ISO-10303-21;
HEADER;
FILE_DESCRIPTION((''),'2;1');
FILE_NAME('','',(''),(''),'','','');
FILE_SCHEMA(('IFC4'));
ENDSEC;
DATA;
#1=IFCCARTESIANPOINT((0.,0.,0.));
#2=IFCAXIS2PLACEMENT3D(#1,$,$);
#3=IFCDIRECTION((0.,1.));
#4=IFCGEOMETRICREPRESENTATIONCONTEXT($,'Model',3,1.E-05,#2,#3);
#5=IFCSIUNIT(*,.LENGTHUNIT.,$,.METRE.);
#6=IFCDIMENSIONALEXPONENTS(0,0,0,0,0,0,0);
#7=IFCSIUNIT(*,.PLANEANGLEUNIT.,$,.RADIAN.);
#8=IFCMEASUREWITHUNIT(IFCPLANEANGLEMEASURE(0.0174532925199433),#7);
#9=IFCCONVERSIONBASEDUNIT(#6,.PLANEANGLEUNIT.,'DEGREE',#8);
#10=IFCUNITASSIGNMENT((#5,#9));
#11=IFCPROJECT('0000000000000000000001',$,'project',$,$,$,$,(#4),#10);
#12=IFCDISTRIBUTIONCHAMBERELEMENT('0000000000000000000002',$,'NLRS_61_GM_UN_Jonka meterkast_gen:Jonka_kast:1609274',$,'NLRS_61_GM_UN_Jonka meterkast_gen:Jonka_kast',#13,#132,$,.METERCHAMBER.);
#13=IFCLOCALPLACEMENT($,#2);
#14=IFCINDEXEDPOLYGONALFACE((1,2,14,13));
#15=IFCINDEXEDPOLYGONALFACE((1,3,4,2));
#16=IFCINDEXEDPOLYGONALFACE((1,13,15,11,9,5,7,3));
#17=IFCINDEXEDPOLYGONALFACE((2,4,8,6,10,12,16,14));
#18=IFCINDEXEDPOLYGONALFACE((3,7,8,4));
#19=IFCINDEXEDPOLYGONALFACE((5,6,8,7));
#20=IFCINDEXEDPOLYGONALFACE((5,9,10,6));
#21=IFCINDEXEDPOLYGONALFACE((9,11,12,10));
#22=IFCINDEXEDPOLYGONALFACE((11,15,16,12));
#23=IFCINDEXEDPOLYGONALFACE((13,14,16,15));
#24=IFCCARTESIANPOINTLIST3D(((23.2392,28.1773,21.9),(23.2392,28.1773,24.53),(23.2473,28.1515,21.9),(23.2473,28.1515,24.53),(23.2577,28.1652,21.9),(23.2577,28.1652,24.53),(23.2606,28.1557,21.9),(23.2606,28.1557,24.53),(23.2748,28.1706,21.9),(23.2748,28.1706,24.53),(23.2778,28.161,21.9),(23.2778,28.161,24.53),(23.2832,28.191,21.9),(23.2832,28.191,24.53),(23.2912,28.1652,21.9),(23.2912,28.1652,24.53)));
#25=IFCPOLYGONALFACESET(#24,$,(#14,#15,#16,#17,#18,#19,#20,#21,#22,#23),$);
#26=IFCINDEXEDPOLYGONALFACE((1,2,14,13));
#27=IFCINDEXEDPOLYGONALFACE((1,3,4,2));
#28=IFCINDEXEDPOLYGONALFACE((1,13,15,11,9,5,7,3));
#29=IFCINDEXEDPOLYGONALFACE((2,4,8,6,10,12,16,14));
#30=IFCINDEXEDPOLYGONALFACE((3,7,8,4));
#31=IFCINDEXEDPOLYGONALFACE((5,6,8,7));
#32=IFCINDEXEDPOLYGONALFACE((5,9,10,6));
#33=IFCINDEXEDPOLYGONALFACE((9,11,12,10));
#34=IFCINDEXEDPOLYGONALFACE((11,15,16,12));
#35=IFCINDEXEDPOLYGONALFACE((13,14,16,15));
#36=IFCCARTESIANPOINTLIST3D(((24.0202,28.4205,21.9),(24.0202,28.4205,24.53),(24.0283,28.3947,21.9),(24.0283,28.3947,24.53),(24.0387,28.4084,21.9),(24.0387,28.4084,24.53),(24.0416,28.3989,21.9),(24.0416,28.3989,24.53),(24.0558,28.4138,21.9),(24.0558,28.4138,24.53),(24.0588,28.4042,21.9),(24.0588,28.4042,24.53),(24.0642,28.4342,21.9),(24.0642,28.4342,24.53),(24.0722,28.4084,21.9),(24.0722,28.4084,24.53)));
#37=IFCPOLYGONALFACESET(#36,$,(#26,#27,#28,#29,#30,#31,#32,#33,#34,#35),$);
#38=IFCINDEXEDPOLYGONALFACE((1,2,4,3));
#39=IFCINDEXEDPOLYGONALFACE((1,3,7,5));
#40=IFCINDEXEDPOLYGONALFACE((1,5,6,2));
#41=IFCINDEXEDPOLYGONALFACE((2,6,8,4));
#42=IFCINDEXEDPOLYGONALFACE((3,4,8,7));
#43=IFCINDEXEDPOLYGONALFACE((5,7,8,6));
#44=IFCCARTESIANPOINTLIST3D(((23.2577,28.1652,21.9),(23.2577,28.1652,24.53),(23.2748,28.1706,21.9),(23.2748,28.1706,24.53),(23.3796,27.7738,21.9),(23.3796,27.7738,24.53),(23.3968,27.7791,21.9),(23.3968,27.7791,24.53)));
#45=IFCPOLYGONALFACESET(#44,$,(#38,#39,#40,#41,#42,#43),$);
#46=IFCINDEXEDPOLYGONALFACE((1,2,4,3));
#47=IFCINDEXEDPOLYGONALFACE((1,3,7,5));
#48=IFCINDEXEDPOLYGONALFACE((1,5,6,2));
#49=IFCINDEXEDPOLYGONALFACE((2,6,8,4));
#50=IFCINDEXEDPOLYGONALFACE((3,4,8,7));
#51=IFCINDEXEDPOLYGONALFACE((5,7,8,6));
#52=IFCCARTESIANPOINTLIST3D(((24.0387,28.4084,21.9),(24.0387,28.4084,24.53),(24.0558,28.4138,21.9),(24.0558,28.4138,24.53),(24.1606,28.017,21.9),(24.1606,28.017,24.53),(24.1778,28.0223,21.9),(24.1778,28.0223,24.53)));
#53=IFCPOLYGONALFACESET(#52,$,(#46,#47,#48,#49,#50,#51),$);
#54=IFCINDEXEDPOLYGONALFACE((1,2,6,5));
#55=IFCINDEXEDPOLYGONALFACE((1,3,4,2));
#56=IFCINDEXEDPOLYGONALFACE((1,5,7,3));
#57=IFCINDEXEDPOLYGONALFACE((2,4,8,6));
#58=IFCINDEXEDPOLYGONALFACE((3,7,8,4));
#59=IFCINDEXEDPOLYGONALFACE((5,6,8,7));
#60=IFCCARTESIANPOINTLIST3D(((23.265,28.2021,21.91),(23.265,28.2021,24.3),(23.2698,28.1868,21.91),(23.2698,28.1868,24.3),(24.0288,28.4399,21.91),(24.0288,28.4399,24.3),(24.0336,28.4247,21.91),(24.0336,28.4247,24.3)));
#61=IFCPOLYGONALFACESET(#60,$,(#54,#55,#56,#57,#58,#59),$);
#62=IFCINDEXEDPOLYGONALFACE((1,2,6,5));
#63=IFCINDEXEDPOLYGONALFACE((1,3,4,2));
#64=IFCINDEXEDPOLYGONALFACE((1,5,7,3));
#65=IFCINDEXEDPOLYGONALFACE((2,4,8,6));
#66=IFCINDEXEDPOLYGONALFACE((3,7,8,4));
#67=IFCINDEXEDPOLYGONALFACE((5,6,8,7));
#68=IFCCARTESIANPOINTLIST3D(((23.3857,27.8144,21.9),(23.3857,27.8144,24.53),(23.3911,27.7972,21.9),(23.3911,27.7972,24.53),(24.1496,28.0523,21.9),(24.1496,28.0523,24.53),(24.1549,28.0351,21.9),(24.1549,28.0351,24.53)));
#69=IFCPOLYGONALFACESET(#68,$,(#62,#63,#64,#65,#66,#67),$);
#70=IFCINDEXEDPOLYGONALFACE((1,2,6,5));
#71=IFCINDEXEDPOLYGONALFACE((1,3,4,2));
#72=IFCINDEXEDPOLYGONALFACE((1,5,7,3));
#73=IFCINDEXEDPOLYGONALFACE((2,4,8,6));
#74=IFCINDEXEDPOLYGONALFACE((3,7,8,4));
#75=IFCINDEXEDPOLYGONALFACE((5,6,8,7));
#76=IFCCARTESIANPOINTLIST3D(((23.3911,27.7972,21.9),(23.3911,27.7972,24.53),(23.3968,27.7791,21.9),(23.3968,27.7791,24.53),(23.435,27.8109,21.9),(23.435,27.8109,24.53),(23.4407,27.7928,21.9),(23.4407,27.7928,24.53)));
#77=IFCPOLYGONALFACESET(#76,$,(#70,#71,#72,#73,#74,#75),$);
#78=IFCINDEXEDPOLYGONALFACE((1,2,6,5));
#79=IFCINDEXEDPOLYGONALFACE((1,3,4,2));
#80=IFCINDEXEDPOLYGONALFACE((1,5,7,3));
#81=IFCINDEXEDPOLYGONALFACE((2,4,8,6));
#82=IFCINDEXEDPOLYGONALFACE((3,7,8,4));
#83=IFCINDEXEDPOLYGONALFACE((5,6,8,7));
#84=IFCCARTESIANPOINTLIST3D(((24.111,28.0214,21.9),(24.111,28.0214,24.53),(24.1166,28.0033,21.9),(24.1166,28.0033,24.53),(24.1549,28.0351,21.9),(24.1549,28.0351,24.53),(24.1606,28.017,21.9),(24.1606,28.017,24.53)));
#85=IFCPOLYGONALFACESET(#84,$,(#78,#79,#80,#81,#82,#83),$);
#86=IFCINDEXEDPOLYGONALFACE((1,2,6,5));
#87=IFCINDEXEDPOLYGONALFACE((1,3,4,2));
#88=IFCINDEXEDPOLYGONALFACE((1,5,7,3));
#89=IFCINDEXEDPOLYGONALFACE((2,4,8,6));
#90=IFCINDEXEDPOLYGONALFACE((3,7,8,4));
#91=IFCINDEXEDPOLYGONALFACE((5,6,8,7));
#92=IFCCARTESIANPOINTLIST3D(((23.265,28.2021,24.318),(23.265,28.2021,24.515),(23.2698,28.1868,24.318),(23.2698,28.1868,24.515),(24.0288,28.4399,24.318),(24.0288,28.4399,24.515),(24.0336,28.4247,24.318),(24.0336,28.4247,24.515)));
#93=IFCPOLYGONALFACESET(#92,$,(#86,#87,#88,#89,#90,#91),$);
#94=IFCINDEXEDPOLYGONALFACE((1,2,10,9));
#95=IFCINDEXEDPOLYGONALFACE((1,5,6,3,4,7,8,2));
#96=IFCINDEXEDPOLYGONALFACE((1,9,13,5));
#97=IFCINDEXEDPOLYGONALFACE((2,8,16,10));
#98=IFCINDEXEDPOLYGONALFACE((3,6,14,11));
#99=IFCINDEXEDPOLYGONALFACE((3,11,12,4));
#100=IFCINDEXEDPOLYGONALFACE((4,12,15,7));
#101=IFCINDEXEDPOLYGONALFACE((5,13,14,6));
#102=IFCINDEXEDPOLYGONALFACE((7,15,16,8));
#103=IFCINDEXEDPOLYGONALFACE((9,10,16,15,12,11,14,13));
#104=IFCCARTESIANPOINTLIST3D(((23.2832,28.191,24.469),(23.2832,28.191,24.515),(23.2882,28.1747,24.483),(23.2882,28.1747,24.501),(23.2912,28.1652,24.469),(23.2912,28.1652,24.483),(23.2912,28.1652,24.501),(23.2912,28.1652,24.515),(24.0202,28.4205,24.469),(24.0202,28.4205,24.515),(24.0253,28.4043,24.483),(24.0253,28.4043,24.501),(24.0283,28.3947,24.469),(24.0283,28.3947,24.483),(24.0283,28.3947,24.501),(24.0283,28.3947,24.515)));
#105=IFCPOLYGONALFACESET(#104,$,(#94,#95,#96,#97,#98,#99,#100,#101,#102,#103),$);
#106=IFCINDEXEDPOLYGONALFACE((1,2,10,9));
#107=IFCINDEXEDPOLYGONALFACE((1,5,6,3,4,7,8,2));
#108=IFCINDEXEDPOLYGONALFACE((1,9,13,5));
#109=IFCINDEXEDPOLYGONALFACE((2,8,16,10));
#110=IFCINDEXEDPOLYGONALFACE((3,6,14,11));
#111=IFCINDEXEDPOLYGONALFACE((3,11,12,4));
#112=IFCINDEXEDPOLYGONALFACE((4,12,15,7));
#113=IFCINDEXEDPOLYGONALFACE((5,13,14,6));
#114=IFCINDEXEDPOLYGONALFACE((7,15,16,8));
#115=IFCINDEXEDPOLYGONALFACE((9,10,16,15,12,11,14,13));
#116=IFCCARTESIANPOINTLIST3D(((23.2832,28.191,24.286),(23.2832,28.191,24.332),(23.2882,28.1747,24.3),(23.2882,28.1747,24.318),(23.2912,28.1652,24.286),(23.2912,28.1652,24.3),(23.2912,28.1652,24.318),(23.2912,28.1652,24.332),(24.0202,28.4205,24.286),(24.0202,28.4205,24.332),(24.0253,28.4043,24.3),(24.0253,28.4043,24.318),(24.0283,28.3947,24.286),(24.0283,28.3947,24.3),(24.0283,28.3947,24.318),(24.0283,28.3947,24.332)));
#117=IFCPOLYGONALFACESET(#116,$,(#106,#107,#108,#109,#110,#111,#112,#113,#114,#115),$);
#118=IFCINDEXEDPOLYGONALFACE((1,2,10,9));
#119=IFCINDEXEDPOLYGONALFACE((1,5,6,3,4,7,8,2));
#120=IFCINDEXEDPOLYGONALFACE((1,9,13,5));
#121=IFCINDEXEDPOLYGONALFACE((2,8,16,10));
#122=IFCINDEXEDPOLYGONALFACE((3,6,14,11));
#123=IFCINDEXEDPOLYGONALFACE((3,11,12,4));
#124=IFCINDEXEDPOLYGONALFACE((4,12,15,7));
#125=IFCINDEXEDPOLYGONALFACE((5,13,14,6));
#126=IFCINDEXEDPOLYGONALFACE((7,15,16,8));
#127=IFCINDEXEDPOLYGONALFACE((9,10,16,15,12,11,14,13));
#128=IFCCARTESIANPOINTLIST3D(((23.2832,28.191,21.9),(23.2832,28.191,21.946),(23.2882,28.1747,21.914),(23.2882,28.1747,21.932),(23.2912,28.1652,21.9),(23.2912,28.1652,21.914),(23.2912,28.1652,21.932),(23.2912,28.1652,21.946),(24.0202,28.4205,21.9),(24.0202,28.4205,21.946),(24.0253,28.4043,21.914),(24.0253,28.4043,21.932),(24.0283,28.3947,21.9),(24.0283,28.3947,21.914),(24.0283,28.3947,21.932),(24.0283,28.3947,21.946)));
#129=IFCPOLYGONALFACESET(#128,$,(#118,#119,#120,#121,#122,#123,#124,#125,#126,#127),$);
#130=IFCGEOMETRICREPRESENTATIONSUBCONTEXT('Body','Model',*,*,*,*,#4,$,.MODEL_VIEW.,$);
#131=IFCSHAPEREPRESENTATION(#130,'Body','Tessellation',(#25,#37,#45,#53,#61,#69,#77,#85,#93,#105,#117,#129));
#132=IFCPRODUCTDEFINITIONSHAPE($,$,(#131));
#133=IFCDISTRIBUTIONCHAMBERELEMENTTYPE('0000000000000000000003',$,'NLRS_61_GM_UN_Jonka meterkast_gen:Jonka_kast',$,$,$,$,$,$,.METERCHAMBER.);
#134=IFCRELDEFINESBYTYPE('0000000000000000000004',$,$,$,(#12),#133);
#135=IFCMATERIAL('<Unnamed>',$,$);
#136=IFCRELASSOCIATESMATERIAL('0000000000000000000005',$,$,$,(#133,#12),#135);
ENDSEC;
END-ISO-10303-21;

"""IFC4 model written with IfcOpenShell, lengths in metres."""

from ifc_helpers import new_model, entity, si_unit, converted_unit, direction, frame, origin, place, context, subcontext, project, indexed_curve, outline, extrude, source, transform, mapped, material, type_object, element, save


model = new_model("IFC4")

# Units and contexts
model_context = context("Model", 3, precision=1e-05, world=origin(), true_north=direction((0.0, 1.0)))
body_context = subcontext(model_context, "Body", "Model", "MODEL_VIEW")
ifc_project = project(units=[si_unit("LENGTHUNIT", "METRE"), converted_unit("PLANEANGLEUNIT", "DEGREE", entity("IfcPlaneAngleMeasure", 0.0174532925199433), si_unit("PLANEANGLEUNIT", "RADIAN"), dimensions=[0, 0, 0, 0, 0, 0, 0])], contexts=[model_context])

# Shared definitions
ifc_material = material(Name="<Unnamed>")
distribution_chamber_element_type = type_object("IfcDistributionChamberElementType", Name="NLRS_61_GM_UN_Jonka meterkast_gen:Jonka_kast", PredefinedType="METERCHAMBER", material=ifc_material)
placement_1 = place(None, frame((13.1348, 11.9886, 0.0), z_axis=(0.0, 0.0, 1.0), x_axis=(0.954771, 0.297342, 0.0)))
placement_2 = place(placement_1, origin())
placement_3 = place(placement_2, frame((0.0, 0.0, 21.9)))

# Distribution chamber element
shared_shape_1 = source(origin(), body_context, "Body", "SweptSolid", [
    extrude(outline(indexed_curve([(-0.023, -0.0093), (-0.009, -0.0093), (-0.009, 0.0007), (0.009, 0.0007), (0.009, -0.0093), (0.023, -0.0093), (0.023, 0.0178), (-0.023, 0.0178), (-0.023, -0.0093)], self_intersect=False)), frame((-0.409, 0.4092, 0.0)), (0.0, 0.0, 1.0), 2.63),
    extrude(outline(indexed_curve([(-0.023, -0.0093), (-0.009, -0.0093), (-0.009, 0.0007), (0.009, 0.0007), (0.009, -0.0093), (0.023, -0.0093), (0.023, 0.0178), (-0.023, 0.0178), (-0.023, -0.0093)], self_intersect=False)), frame((0.409, 0.4092, 0.0)), (0.0, 0.0, 1.0), 2.63),
    extrude(outline(indexed_curve([(-0.009, -0.205), (0.009, -0.205), (0.009, 0.205), (-0.009, 0.205), (-0.009, -0.205)], self_intersect=False)), frame((-0.409, 0.205, 0.0)), (0.0, 0.0, 1.0), 2.63),
    extrude(outline(indexed_curve([(-0.009, -0.205), (0.009, -0.205), (0.009, 0.205), (-0.009, 0.205), (-0.009, -0.205)], self_intersect=False)), frame((0.409, 0.205, 0.0)), (0.0, 0.0, 1.0), 2.63),
    extrude(outline(indexed_curve([(-0.008, -0.4), (0.008, -0.4), (0.008, 0.4), (-0.008, 0.4), (-0.008, -0.4)], self_intersect=False)), frame((0.0, 0.435, 0.01), z_axis=(0.0, 0.0, 1.0), x_axis=(0.0, 1.0, 0.0)), (0.0, 0.0, 1.0), 2.39),
    extrude(outline(indexed_curve([(-0.009, -0.4), (0.009, -0.4), (0.009, 0.4), (-0.009, 0.4), (-0.009, -0.4)], self_intersect=False)), frame((0.0, 0.028, 0.0), z_axis=(0.0, 0.0, 1.0), x_axis=(0.0, 1.0, 0.0)), (0.0, 0.0, 1.0), 2.63),
    extrude(outline(indexed_curve([(-0.0095, -0.023), (0.0095, -0.023), (0.0095, 0.023), (-0.0095, 0.023), (-0.0095, -0.023)], self_intersect=False)), frame((-0.377, 0.0095, 0.0), z_axis=(0.0, 0.0, 1.0), x_axis=(0.0, 1.0, 0.0)), (0.0, 0.0, 1.0), 2.63),
    extrude(outline(indexed_curve([(-0.0095, -0.023), (0.0095, -0.023), (0.0095, 0.023), (-0.0095, 0.023), (-0.0095, -0.023)], self_intersect=False)), frame((0.377, 0.0095, 0.0), z_axis=(0.0, 0.0, 1.0), x_axis=(0.0, 1.0, 0.0)), (0.0, 0.0, 1.0), 2.63),
    extrude(outline(indexed_curve([(-0.008, -0.4), (0.008, -0.4), (0.008, 0.4), (-0.008, 0.4), (-0.008, -0.4)], self_intersect=False)), frame((0.0, 0.435, 2.418), z_axis=(0.0, 0.0, 1.0), x_axis=(0.0, 1.0, 0.0)), (0.0, 0.0, 1.0), 0.197),
    extrude(outline(indexed_curve([(-0.0178, -0.023), (0.0093, -0.023), (0.0093, -0.009), (-0.0007, -0.009), (-0.0007, 0.009), (0.0093, 0.009), (0.0093, 0.023), (-0.0178, 0.023), (-0.0178, -0.023)], self_intersect=False)), frame((-0.386, 0.4092, 2.592), z_axis=(1.0, 0.0, 0.0), x_axis=(0.0, -1.0, 0.0)), (0.0, 0.0, 1.0), 0.772),
    extrude(outline(indexed_curve([(-0.0178, -0.023), (0.0093, -0.023), (0.0093, -0.009), (-0.0007, -0.009), (-0.0007, 0.009), (0.0093, 0.009), (0.0093, 0.023), (-0.0178, 0.023), (-0.0178, -0.023)], self_intersect=False)), frame((-0.386, 0.4092, 2.409), z_axis=(1.0, 0.0, 0.0), x_axis=(0.0, -1.0, 0.0)), (0.0, 0.0, 1.0), 0.772),
    extrude(outline(indexed_curve([(-0.0178, -0.023), (0.0093, -0.023), (0.0093, -0.009), (-0.0007, -0.009), (-0.0007, 0.009), (0.0093, 0.009), (0.0093, 0.023), (-0.0178, 0.023), (-0.0178, -0.023)], self_intersect=False)), frame((-0.386, 0.4092, 0.023), z_axis=(1.0, 0.0, 0.0), x_axis=(0.0, -1.0, 0.0)), (0.0, 0.0, 1.0), 0.772),
])
placement_4 = place(placement_3, origin())
distribution_chamber_element_1_placement = place(placement_4, frame((14.893, 12.025, 0.0)))
element("IfcDistributionChamberElement", 1, at=distribution_chamber_element_1_placement, type_object=distribution_chamber_element_type, material=ifc_material, Name="NLRS_61_GM_UN_Jonka meterkast_gen:Jonka_kast:1609274", ObjectType="NLRS_61_GM_UN_Jonka meterkast_gen:Jonka_kast", PredefinedType="METERCHAMBER", context=body_context, shape_type="MappedRepresentation", body=[
    mapped(shared_shape_1, transform((0.0, 0.0, 0.0), scale=1.0)),
])

save(model, "model.ifc")
